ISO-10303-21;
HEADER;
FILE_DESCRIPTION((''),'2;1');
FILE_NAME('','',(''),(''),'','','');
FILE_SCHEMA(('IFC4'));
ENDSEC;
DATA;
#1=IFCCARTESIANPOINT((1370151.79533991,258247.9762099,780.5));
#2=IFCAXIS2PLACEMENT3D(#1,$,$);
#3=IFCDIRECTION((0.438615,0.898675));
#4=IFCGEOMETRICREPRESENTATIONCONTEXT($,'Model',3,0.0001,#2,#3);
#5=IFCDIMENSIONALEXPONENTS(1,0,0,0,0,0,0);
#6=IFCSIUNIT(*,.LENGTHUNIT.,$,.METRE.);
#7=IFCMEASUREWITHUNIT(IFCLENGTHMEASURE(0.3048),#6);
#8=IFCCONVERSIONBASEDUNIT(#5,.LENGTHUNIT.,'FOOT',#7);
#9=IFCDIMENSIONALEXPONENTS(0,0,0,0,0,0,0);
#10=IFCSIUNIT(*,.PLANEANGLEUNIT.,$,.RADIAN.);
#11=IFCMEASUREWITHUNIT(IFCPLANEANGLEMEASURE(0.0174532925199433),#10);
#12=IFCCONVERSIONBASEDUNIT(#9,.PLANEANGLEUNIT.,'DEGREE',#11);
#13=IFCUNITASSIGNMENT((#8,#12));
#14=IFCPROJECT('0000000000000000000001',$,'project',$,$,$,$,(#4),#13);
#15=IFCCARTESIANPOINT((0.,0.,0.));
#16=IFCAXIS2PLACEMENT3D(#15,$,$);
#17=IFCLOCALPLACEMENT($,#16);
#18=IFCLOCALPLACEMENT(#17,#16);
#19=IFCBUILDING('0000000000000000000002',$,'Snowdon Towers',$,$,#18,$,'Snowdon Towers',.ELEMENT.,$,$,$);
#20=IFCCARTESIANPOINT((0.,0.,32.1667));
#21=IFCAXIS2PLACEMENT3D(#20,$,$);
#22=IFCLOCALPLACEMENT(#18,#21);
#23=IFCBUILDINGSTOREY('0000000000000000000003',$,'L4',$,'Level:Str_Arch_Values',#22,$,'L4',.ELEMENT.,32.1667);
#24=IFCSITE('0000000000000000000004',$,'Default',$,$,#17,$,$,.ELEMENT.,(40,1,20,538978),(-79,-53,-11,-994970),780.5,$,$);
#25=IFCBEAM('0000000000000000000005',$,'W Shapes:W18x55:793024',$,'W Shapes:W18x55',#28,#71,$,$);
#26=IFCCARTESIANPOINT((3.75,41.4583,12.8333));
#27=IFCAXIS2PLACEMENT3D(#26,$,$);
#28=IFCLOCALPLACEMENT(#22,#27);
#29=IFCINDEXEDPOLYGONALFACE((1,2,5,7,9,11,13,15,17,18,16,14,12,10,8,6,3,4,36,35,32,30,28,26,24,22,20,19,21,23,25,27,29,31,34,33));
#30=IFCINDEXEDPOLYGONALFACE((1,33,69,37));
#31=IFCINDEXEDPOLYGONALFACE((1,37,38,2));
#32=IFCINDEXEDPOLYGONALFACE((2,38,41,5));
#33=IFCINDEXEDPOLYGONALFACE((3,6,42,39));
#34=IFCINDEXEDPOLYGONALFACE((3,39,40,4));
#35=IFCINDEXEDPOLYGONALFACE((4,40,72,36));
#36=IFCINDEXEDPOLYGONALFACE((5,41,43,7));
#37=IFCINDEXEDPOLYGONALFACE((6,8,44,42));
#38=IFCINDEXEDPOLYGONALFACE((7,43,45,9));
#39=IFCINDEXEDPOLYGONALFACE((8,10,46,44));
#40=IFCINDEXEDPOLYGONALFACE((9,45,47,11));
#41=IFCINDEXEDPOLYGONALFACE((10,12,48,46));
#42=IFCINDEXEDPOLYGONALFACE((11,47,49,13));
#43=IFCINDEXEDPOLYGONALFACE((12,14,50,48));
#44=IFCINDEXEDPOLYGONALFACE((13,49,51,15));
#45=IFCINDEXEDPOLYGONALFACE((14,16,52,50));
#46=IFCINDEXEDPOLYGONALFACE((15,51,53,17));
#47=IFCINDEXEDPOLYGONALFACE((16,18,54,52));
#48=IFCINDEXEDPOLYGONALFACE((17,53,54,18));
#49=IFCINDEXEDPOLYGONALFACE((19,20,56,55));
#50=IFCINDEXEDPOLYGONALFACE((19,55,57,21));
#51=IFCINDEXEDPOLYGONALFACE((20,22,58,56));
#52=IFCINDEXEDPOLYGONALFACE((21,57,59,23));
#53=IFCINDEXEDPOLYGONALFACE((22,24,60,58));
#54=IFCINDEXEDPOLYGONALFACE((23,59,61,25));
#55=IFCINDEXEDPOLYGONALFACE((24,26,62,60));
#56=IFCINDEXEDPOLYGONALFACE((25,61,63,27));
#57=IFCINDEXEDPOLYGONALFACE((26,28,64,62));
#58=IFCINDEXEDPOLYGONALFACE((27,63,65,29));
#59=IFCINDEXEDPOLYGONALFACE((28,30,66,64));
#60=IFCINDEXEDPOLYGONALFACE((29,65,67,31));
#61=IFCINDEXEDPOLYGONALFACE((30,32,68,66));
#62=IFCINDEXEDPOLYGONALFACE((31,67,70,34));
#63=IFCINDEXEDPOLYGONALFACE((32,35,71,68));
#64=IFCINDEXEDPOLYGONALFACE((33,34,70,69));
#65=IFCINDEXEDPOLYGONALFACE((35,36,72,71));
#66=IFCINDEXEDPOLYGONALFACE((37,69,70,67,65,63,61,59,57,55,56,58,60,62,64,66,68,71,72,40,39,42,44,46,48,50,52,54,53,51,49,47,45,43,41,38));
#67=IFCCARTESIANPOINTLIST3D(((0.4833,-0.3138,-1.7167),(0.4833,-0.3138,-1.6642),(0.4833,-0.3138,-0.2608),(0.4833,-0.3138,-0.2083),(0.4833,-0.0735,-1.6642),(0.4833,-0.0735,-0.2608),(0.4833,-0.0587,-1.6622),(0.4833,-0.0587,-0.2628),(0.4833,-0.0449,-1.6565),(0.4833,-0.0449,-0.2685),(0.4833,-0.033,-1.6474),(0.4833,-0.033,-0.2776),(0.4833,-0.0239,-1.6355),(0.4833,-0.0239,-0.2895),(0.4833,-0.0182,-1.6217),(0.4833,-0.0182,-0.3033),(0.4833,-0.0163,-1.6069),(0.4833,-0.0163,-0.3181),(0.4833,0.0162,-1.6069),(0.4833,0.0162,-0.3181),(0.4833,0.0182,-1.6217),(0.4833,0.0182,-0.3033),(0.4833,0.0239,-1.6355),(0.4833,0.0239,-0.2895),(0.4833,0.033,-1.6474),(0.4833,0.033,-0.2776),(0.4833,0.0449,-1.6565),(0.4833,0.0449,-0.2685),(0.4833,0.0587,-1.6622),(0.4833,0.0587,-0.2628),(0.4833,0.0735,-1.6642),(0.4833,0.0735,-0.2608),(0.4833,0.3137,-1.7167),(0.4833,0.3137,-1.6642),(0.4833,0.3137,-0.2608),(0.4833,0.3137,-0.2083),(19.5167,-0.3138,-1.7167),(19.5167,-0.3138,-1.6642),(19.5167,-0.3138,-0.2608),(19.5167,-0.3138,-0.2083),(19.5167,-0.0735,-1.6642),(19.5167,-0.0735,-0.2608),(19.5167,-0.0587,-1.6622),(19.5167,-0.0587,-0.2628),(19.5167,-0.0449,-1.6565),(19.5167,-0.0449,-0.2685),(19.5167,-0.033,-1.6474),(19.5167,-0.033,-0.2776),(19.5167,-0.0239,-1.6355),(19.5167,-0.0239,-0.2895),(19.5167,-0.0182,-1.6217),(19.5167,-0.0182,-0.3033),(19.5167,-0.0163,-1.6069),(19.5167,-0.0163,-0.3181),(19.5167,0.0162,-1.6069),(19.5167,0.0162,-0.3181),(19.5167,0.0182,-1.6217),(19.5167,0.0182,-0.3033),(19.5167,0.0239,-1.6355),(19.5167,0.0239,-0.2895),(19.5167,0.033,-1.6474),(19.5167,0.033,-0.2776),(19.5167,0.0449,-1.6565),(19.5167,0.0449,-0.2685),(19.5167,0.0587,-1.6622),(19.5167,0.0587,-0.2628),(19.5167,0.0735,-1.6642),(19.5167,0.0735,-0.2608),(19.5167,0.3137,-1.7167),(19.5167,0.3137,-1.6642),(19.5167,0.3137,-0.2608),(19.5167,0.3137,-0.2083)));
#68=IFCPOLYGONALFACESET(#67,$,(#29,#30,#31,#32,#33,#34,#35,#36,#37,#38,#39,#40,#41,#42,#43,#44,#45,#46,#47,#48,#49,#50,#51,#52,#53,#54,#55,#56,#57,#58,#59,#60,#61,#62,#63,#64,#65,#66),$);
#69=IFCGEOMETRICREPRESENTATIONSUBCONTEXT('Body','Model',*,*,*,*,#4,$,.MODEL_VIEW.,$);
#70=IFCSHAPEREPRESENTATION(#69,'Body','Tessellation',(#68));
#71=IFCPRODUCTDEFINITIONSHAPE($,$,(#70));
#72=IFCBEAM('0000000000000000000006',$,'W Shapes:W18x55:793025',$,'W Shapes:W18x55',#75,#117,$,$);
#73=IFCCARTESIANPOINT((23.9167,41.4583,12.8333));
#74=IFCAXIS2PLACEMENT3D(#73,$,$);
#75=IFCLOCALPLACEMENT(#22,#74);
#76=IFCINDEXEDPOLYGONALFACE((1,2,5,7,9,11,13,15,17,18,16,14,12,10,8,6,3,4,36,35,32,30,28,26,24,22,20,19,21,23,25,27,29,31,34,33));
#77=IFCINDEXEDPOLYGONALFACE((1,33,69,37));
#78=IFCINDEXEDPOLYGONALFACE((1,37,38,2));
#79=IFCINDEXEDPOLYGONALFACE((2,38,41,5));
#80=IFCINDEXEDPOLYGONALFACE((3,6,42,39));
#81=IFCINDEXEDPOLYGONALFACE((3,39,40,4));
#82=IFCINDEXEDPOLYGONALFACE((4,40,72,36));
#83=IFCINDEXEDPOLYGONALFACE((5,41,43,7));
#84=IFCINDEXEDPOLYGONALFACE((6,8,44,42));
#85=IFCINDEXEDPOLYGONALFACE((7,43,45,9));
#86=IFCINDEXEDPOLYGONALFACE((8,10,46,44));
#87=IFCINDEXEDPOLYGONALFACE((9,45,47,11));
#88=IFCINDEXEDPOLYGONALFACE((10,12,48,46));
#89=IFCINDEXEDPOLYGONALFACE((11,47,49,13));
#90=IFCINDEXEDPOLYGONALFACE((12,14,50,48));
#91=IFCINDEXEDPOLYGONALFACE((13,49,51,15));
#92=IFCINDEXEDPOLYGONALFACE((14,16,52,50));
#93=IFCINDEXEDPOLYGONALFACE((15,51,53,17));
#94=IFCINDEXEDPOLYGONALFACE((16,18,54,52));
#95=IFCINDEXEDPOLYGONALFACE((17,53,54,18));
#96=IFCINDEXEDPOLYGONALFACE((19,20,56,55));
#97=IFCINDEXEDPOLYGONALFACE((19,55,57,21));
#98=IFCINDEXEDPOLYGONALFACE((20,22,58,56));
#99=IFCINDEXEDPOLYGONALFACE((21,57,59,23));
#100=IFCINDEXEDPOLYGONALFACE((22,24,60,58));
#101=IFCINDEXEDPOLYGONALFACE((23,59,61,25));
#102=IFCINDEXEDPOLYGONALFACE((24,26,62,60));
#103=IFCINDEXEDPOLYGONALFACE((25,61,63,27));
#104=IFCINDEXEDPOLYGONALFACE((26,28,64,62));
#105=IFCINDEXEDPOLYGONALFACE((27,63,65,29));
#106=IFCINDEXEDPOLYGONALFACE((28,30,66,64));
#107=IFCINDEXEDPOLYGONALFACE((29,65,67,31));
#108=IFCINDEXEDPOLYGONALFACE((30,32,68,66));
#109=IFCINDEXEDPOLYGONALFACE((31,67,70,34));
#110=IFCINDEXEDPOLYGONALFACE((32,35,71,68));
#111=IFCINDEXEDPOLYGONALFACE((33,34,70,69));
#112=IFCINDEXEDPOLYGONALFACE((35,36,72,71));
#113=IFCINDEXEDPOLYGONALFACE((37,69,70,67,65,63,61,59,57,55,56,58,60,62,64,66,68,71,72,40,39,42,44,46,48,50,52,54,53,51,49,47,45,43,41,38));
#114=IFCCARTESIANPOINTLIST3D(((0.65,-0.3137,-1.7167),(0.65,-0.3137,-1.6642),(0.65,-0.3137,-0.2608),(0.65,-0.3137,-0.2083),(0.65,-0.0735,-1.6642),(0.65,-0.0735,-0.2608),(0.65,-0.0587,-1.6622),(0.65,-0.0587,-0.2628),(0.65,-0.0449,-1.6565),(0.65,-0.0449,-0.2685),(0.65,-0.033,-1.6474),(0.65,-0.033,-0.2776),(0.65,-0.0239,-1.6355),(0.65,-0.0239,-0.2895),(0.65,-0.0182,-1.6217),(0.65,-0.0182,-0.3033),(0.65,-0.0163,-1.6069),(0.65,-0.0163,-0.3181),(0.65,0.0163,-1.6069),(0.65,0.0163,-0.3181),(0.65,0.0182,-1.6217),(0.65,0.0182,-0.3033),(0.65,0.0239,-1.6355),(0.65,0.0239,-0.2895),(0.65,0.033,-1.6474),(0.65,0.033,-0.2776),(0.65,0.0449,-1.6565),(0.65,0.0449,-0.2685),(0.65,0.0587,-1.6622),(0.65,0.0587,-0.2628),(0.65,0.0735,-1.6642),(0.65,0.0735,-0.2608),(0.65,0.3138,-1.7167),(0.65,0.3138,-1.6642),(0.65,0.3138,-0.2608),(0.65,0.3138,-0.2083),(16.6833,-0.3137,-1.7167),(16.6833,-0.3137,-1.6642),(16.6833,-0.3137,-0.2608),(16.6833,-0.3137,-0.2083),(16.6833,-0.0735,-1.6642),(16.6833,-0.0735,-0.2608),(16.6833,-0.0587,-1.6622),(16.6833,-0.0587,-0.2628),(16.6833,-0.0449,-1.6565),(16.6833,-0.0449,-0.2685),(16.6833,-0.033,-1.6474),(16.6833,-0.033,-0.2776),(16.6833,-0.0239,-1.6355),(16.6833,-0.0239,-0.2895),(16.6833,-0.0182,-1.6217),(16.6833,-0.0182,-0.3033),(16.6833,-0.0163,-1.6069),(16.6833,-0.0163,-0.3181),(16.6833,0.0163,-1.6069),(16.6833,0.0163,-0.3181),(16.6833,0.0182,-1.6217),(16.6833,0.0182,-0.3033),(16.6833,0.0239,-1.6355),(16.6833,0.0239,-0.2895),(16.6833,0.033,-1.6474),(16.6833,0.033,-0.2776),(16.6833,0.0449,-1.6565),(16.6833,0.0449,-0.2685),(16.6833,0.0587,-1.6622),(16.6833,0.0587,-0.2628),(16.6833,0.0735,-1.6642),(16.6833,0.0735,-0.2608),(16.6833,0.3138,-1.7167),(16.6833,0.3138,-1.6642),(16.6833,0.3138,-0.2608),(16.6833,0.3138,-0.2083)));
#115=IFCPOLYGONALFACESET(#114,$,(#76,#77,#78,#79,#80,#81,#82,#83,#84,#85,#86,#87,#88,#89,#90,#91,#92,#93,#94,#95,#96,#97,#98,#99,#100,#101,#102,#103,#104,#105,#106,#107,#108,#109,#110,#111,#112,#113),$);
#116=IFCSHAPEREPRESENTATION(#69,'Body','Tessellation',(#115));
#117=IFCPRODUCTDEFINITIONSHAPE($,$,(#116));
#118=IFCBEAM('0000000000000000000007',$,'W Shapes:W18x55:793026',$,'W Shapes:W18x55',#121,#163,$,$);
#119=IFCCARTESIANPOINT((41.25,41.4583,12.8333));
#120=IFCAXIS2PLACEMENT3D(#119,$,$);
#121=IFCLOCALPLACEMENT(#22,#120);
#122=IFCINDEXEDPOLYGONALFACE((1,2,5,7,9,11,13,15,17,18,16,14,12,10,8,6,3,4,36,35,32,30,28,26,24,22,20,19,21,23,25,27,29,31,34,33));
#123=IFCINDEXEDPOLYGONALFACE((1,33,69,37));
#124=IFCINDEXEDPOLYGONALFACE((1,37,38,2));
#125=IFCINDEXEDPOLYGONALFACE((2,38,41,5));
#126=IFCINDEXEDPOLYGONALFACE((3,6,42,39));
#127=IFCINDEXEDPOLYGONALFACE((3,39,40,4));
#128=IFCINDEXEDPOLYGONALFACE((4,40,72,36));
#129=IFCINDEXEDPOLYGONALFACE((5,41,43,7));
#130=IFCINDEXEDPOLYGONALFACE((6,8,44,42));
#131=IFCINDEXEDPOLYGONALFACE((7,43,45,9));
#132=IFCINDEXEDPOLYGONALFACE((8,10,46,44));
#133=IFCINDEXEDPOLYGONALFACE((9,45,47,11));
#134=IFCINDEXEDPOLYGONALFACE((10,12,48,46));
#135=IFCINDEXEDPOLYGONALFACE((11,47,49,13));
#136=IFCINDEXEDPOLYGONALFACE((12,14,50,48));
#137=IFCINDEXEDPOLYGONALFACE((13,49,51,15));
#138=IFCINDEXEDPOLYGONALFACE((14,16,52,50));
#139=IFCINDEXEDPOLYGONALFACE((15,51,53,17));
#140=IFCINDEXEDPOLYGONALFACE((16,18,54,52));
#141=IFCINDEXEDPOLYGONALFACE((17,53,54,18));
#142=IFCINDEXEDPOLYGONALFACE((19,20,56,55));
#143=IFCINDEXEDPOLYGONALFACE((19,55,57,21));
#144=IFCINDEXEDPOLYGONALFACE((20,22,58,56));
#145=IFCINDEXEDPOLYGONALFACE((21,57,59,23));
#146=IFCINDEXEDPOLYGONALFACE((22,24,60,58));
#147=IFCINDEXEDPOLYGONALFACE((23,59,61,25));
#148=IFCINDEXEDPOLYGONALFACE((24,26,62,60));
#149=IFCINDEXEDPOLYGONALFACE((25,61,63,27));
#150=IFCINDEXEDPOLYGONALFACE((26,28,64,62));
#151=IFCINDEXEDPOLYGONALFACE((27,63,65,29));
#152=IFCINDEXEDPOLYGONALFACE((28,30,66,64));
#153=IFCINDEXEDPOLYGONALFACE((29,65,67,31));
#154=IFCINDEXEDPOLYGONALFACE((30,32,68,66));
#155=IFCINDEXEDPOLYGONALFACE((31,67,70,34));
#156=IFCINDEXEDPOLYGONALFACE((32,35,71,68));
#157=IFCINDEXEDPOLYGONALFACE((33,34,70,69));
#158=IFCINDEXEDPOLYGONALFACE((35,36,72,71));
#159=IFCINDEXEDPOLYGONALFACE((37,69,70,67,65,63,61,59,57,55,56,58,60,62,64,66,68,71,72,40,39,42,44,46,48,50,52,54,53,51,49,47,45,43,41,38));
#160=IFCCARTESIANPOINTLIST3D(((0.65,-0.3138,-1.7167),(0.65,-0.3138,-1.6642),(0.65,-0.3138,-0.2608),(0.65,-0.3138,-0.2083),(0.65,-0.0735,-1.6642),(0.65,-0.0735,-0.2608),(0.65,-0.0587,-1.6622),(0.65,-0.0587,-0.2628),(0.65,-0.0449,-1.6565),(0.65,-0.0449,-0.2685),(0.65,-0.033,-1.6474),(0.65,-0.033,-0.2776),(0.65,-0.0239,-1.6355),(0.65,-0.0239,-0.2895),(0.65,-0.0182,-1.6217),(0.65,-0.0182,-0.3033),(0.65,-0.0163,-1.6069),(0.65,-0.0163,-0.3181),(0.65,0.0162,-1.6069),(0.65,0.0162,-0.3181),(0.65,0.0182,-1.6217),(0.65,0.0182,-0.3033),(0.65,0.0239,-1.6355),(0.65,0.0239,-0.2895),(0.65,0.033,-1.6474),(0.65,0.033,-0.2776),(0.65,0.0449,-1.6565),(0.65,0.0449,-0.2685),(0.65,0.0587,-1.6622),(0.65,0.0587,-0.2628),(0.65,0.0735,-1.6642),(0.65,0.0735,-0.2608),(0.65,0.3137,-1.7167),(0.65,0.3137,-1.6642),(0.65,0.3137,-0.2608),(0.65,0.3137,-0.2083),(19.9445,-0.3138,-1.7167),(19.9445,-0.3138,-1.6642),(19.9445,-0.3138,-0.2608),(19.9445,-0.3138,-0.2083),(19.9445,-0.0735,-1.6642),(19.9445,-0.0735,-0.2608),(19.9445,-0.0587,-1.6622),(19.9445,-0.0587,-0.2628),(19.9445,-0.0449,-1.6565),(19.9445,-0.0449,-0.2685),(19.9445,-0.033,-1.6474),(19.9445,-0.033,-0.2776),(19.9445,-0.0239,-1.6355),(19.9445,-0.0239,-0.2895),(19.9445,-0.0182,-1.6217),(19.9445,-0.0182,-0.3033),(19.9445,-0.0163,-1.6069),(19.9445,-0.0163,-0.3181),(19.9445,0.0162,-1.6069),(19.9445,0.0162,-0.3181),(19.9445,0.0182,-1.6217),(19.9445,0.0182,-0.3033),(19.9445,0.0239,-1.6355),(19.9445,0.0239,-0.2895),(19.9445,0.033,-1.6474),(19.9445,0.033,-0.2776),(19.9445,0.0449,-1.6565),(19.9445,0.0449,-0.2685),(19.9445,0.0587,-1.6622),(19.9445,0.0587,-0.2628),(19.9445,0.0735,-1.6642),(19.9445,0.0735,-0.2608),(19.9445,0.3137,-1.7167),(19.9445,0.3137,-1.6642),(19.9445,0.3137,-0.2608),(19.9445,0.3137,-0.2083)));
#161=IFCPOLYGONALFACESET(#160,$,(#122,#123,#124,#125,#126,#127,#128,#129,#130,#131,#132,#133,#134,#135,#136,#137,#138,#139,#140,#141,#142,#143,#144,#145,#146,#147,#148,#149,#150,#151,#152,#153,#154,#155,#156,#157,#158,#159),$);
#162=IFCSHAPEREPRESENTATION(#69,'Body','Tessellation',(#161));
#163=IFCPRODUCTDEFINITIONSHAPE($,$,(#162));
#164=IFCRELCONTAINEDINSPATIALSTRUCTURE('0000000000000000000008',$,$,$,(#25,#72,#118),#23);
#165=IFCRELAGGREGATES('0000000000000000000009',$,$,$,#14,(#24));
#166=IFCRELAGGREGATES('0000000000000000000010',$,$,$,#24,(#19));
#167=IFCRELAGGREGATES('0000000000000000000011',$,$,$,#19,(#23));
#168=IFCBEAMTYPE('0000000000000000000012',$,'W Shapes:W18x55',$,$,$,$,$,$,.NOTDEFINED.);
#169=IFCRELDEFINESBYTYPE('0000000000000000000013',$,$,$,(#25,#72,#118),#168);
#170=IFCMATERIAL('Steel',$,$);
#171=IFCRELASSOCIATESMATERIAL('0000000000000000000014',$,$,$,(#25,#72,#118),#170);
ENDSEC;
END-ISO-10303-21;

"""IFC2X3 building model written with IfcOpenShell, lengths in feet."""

from ifc_helpers import new_model, entity, si_unit, converted_unit, direction, frame, frame_2d, origin, place, context, subcontext, project, spatial, i_section, extrude, material, type_object, element, save


model = new_model("IFC2X3")

# Units and contexts
model_context = context("Model", 3, precision=0.0001, world=frame((1370151.79533991, 258247.9762099, 780.5)), true_north=direction((0.438615, 0.898675)))
body_context = subcontext(model_context, "Body", "Model", "MODEL_VIEW")
ifc_project = project(units=[converted_unit("LENGTHUNIT", "FOOT", entity("IfcLengthMeasure", 0.3048), si_unit("LENGTHUNIT", "METRE"), dimensions=[1, 0, 0, 0, 0, 0, 0]), converted_unit("PLANEANGLEUNIT", "DEGREE", entity("IfcPlaneAngleMeasure", 0.0174532925199433), si_unit("PLANEANGLEUNIT", "RADIAN"), dimensions=[0, 0, 0, 0, 0, 0, 0])], contexts=[model_context])

# Site, building, storey
site_placement = place(None, origin())
site = spatial("IfcSite", under=ifc_project, at=site_placement, Name="Default", CompositionType="ELEMENT", RefLatitude=(40, 1, 20, 538978), RefLongitude=(-79, -53, -11, -994970), RefElevation=780.5)
building_placement = place(site_placement, origin())
building = spatial("IfcBuilding", under=site, at=building_placement, Name="Snowdon Towers", LongName="Snowdon Towers", CompositionType="ELEMENT")
storey_placement = place(building_placement, frame((0.0, 0.0, 32.1667)))
storey = spatial("IfcBuildingStorey", under=building, at=storey_placement, Name="L4", ObjectType="Level:Str_Arch_Values", LongName="L4", CompositionType="ELEMENT", Elevation=32.1667)

# Beams
ifc_material = material(Name="Steel")
beam_type_1 = type_object("IfcBeamType", Name="W Shapes:W18x55", PredefinedType="NOTDEFINED")
beam_1_placement = place(storey_placement, frame((3.75, 41.4583, 12.8333)))
element("IfcBeam", 1, at=beam_1_placement, inside=storey, type_object=beam_type_1, material=ifc_material, Name="W Shapes:W18x55:793024", ObjectType="W Shapes:W18x55", context=body_context, shape_type="SweptSolid", body=[
    extrude(i_section(OverallWidth=0.6275, OverallDepth=1.5083, WebThickness=0.0325, FlangeThickness=0.0525, FilletRadius=0.0573, at=frame_2d((0.0, 0.0), x_axis=(0.0, 1.0))), frame((0.4833, 0.0, -0.9625), z_axis=(1.0, 0.0, 0.0), x_axis=(0.0, 0.0, -1.0)), (0.0, 0.0, 1.0), 19.0333),
])
beam_2_placement = place(storey_placement, frame((23.9167, 41.4583, 12.8333)))
element("IfcBeam", 2, at=beam_2_placement, inside=storey, type_object=beam_type_1, material=ifc_material, Name="W Shapes:W18x55:793025", ObjectType="W Shapes:W18x55", context=body_context, shape_type="SweptSolid", body=[
    extrude(i_section(OverallWidth=0.6275, OverallDepth=1.5083, WebThickness=0.0325, FlangeThickness=0.0525, FilletRadius=0.0573, at=frame_2d((0.0, 0.0), x_axis=(0.0, 1.0))), frame((0.65, 0.0, -0.9625), z_axis=(1.0, 0.0, 0.0), x_axis=(0.0, 0.0, -1.0)), (0.0, 0.0, 1.0), 16.0333),
])
beam_3_placement = place(storey_placement, frame((41.25, 41.4583, 12.8333)))
element("IfcBeam", 3, at=beam_3_placement, inside=storey, type_object=beam_type_1, material=ifc_material, Name="W Shapes:W18x55:793026", ObjectType="W Shapes:W18x55", context=body_context, shape_type="SweptSolid", body=[
    extrude(i_section(OverallWidth=0.6275, OverallDepth=1.5083, WebThickness=0.0325, FlangeThickness=0.0525, FilletRadius=0.0573, at=frame_2d((0.0, 0.0), x_axis=(0.0, 1.0))), frame((0.65, 0.0, -0.9625), z_axis=(1.0, 0.0, 0.0), x_axis=(0.0, 0.0, -1.0)), (0.0, 0.0, 1.0), 19.2945),
])

save(model, "model.ifc")
